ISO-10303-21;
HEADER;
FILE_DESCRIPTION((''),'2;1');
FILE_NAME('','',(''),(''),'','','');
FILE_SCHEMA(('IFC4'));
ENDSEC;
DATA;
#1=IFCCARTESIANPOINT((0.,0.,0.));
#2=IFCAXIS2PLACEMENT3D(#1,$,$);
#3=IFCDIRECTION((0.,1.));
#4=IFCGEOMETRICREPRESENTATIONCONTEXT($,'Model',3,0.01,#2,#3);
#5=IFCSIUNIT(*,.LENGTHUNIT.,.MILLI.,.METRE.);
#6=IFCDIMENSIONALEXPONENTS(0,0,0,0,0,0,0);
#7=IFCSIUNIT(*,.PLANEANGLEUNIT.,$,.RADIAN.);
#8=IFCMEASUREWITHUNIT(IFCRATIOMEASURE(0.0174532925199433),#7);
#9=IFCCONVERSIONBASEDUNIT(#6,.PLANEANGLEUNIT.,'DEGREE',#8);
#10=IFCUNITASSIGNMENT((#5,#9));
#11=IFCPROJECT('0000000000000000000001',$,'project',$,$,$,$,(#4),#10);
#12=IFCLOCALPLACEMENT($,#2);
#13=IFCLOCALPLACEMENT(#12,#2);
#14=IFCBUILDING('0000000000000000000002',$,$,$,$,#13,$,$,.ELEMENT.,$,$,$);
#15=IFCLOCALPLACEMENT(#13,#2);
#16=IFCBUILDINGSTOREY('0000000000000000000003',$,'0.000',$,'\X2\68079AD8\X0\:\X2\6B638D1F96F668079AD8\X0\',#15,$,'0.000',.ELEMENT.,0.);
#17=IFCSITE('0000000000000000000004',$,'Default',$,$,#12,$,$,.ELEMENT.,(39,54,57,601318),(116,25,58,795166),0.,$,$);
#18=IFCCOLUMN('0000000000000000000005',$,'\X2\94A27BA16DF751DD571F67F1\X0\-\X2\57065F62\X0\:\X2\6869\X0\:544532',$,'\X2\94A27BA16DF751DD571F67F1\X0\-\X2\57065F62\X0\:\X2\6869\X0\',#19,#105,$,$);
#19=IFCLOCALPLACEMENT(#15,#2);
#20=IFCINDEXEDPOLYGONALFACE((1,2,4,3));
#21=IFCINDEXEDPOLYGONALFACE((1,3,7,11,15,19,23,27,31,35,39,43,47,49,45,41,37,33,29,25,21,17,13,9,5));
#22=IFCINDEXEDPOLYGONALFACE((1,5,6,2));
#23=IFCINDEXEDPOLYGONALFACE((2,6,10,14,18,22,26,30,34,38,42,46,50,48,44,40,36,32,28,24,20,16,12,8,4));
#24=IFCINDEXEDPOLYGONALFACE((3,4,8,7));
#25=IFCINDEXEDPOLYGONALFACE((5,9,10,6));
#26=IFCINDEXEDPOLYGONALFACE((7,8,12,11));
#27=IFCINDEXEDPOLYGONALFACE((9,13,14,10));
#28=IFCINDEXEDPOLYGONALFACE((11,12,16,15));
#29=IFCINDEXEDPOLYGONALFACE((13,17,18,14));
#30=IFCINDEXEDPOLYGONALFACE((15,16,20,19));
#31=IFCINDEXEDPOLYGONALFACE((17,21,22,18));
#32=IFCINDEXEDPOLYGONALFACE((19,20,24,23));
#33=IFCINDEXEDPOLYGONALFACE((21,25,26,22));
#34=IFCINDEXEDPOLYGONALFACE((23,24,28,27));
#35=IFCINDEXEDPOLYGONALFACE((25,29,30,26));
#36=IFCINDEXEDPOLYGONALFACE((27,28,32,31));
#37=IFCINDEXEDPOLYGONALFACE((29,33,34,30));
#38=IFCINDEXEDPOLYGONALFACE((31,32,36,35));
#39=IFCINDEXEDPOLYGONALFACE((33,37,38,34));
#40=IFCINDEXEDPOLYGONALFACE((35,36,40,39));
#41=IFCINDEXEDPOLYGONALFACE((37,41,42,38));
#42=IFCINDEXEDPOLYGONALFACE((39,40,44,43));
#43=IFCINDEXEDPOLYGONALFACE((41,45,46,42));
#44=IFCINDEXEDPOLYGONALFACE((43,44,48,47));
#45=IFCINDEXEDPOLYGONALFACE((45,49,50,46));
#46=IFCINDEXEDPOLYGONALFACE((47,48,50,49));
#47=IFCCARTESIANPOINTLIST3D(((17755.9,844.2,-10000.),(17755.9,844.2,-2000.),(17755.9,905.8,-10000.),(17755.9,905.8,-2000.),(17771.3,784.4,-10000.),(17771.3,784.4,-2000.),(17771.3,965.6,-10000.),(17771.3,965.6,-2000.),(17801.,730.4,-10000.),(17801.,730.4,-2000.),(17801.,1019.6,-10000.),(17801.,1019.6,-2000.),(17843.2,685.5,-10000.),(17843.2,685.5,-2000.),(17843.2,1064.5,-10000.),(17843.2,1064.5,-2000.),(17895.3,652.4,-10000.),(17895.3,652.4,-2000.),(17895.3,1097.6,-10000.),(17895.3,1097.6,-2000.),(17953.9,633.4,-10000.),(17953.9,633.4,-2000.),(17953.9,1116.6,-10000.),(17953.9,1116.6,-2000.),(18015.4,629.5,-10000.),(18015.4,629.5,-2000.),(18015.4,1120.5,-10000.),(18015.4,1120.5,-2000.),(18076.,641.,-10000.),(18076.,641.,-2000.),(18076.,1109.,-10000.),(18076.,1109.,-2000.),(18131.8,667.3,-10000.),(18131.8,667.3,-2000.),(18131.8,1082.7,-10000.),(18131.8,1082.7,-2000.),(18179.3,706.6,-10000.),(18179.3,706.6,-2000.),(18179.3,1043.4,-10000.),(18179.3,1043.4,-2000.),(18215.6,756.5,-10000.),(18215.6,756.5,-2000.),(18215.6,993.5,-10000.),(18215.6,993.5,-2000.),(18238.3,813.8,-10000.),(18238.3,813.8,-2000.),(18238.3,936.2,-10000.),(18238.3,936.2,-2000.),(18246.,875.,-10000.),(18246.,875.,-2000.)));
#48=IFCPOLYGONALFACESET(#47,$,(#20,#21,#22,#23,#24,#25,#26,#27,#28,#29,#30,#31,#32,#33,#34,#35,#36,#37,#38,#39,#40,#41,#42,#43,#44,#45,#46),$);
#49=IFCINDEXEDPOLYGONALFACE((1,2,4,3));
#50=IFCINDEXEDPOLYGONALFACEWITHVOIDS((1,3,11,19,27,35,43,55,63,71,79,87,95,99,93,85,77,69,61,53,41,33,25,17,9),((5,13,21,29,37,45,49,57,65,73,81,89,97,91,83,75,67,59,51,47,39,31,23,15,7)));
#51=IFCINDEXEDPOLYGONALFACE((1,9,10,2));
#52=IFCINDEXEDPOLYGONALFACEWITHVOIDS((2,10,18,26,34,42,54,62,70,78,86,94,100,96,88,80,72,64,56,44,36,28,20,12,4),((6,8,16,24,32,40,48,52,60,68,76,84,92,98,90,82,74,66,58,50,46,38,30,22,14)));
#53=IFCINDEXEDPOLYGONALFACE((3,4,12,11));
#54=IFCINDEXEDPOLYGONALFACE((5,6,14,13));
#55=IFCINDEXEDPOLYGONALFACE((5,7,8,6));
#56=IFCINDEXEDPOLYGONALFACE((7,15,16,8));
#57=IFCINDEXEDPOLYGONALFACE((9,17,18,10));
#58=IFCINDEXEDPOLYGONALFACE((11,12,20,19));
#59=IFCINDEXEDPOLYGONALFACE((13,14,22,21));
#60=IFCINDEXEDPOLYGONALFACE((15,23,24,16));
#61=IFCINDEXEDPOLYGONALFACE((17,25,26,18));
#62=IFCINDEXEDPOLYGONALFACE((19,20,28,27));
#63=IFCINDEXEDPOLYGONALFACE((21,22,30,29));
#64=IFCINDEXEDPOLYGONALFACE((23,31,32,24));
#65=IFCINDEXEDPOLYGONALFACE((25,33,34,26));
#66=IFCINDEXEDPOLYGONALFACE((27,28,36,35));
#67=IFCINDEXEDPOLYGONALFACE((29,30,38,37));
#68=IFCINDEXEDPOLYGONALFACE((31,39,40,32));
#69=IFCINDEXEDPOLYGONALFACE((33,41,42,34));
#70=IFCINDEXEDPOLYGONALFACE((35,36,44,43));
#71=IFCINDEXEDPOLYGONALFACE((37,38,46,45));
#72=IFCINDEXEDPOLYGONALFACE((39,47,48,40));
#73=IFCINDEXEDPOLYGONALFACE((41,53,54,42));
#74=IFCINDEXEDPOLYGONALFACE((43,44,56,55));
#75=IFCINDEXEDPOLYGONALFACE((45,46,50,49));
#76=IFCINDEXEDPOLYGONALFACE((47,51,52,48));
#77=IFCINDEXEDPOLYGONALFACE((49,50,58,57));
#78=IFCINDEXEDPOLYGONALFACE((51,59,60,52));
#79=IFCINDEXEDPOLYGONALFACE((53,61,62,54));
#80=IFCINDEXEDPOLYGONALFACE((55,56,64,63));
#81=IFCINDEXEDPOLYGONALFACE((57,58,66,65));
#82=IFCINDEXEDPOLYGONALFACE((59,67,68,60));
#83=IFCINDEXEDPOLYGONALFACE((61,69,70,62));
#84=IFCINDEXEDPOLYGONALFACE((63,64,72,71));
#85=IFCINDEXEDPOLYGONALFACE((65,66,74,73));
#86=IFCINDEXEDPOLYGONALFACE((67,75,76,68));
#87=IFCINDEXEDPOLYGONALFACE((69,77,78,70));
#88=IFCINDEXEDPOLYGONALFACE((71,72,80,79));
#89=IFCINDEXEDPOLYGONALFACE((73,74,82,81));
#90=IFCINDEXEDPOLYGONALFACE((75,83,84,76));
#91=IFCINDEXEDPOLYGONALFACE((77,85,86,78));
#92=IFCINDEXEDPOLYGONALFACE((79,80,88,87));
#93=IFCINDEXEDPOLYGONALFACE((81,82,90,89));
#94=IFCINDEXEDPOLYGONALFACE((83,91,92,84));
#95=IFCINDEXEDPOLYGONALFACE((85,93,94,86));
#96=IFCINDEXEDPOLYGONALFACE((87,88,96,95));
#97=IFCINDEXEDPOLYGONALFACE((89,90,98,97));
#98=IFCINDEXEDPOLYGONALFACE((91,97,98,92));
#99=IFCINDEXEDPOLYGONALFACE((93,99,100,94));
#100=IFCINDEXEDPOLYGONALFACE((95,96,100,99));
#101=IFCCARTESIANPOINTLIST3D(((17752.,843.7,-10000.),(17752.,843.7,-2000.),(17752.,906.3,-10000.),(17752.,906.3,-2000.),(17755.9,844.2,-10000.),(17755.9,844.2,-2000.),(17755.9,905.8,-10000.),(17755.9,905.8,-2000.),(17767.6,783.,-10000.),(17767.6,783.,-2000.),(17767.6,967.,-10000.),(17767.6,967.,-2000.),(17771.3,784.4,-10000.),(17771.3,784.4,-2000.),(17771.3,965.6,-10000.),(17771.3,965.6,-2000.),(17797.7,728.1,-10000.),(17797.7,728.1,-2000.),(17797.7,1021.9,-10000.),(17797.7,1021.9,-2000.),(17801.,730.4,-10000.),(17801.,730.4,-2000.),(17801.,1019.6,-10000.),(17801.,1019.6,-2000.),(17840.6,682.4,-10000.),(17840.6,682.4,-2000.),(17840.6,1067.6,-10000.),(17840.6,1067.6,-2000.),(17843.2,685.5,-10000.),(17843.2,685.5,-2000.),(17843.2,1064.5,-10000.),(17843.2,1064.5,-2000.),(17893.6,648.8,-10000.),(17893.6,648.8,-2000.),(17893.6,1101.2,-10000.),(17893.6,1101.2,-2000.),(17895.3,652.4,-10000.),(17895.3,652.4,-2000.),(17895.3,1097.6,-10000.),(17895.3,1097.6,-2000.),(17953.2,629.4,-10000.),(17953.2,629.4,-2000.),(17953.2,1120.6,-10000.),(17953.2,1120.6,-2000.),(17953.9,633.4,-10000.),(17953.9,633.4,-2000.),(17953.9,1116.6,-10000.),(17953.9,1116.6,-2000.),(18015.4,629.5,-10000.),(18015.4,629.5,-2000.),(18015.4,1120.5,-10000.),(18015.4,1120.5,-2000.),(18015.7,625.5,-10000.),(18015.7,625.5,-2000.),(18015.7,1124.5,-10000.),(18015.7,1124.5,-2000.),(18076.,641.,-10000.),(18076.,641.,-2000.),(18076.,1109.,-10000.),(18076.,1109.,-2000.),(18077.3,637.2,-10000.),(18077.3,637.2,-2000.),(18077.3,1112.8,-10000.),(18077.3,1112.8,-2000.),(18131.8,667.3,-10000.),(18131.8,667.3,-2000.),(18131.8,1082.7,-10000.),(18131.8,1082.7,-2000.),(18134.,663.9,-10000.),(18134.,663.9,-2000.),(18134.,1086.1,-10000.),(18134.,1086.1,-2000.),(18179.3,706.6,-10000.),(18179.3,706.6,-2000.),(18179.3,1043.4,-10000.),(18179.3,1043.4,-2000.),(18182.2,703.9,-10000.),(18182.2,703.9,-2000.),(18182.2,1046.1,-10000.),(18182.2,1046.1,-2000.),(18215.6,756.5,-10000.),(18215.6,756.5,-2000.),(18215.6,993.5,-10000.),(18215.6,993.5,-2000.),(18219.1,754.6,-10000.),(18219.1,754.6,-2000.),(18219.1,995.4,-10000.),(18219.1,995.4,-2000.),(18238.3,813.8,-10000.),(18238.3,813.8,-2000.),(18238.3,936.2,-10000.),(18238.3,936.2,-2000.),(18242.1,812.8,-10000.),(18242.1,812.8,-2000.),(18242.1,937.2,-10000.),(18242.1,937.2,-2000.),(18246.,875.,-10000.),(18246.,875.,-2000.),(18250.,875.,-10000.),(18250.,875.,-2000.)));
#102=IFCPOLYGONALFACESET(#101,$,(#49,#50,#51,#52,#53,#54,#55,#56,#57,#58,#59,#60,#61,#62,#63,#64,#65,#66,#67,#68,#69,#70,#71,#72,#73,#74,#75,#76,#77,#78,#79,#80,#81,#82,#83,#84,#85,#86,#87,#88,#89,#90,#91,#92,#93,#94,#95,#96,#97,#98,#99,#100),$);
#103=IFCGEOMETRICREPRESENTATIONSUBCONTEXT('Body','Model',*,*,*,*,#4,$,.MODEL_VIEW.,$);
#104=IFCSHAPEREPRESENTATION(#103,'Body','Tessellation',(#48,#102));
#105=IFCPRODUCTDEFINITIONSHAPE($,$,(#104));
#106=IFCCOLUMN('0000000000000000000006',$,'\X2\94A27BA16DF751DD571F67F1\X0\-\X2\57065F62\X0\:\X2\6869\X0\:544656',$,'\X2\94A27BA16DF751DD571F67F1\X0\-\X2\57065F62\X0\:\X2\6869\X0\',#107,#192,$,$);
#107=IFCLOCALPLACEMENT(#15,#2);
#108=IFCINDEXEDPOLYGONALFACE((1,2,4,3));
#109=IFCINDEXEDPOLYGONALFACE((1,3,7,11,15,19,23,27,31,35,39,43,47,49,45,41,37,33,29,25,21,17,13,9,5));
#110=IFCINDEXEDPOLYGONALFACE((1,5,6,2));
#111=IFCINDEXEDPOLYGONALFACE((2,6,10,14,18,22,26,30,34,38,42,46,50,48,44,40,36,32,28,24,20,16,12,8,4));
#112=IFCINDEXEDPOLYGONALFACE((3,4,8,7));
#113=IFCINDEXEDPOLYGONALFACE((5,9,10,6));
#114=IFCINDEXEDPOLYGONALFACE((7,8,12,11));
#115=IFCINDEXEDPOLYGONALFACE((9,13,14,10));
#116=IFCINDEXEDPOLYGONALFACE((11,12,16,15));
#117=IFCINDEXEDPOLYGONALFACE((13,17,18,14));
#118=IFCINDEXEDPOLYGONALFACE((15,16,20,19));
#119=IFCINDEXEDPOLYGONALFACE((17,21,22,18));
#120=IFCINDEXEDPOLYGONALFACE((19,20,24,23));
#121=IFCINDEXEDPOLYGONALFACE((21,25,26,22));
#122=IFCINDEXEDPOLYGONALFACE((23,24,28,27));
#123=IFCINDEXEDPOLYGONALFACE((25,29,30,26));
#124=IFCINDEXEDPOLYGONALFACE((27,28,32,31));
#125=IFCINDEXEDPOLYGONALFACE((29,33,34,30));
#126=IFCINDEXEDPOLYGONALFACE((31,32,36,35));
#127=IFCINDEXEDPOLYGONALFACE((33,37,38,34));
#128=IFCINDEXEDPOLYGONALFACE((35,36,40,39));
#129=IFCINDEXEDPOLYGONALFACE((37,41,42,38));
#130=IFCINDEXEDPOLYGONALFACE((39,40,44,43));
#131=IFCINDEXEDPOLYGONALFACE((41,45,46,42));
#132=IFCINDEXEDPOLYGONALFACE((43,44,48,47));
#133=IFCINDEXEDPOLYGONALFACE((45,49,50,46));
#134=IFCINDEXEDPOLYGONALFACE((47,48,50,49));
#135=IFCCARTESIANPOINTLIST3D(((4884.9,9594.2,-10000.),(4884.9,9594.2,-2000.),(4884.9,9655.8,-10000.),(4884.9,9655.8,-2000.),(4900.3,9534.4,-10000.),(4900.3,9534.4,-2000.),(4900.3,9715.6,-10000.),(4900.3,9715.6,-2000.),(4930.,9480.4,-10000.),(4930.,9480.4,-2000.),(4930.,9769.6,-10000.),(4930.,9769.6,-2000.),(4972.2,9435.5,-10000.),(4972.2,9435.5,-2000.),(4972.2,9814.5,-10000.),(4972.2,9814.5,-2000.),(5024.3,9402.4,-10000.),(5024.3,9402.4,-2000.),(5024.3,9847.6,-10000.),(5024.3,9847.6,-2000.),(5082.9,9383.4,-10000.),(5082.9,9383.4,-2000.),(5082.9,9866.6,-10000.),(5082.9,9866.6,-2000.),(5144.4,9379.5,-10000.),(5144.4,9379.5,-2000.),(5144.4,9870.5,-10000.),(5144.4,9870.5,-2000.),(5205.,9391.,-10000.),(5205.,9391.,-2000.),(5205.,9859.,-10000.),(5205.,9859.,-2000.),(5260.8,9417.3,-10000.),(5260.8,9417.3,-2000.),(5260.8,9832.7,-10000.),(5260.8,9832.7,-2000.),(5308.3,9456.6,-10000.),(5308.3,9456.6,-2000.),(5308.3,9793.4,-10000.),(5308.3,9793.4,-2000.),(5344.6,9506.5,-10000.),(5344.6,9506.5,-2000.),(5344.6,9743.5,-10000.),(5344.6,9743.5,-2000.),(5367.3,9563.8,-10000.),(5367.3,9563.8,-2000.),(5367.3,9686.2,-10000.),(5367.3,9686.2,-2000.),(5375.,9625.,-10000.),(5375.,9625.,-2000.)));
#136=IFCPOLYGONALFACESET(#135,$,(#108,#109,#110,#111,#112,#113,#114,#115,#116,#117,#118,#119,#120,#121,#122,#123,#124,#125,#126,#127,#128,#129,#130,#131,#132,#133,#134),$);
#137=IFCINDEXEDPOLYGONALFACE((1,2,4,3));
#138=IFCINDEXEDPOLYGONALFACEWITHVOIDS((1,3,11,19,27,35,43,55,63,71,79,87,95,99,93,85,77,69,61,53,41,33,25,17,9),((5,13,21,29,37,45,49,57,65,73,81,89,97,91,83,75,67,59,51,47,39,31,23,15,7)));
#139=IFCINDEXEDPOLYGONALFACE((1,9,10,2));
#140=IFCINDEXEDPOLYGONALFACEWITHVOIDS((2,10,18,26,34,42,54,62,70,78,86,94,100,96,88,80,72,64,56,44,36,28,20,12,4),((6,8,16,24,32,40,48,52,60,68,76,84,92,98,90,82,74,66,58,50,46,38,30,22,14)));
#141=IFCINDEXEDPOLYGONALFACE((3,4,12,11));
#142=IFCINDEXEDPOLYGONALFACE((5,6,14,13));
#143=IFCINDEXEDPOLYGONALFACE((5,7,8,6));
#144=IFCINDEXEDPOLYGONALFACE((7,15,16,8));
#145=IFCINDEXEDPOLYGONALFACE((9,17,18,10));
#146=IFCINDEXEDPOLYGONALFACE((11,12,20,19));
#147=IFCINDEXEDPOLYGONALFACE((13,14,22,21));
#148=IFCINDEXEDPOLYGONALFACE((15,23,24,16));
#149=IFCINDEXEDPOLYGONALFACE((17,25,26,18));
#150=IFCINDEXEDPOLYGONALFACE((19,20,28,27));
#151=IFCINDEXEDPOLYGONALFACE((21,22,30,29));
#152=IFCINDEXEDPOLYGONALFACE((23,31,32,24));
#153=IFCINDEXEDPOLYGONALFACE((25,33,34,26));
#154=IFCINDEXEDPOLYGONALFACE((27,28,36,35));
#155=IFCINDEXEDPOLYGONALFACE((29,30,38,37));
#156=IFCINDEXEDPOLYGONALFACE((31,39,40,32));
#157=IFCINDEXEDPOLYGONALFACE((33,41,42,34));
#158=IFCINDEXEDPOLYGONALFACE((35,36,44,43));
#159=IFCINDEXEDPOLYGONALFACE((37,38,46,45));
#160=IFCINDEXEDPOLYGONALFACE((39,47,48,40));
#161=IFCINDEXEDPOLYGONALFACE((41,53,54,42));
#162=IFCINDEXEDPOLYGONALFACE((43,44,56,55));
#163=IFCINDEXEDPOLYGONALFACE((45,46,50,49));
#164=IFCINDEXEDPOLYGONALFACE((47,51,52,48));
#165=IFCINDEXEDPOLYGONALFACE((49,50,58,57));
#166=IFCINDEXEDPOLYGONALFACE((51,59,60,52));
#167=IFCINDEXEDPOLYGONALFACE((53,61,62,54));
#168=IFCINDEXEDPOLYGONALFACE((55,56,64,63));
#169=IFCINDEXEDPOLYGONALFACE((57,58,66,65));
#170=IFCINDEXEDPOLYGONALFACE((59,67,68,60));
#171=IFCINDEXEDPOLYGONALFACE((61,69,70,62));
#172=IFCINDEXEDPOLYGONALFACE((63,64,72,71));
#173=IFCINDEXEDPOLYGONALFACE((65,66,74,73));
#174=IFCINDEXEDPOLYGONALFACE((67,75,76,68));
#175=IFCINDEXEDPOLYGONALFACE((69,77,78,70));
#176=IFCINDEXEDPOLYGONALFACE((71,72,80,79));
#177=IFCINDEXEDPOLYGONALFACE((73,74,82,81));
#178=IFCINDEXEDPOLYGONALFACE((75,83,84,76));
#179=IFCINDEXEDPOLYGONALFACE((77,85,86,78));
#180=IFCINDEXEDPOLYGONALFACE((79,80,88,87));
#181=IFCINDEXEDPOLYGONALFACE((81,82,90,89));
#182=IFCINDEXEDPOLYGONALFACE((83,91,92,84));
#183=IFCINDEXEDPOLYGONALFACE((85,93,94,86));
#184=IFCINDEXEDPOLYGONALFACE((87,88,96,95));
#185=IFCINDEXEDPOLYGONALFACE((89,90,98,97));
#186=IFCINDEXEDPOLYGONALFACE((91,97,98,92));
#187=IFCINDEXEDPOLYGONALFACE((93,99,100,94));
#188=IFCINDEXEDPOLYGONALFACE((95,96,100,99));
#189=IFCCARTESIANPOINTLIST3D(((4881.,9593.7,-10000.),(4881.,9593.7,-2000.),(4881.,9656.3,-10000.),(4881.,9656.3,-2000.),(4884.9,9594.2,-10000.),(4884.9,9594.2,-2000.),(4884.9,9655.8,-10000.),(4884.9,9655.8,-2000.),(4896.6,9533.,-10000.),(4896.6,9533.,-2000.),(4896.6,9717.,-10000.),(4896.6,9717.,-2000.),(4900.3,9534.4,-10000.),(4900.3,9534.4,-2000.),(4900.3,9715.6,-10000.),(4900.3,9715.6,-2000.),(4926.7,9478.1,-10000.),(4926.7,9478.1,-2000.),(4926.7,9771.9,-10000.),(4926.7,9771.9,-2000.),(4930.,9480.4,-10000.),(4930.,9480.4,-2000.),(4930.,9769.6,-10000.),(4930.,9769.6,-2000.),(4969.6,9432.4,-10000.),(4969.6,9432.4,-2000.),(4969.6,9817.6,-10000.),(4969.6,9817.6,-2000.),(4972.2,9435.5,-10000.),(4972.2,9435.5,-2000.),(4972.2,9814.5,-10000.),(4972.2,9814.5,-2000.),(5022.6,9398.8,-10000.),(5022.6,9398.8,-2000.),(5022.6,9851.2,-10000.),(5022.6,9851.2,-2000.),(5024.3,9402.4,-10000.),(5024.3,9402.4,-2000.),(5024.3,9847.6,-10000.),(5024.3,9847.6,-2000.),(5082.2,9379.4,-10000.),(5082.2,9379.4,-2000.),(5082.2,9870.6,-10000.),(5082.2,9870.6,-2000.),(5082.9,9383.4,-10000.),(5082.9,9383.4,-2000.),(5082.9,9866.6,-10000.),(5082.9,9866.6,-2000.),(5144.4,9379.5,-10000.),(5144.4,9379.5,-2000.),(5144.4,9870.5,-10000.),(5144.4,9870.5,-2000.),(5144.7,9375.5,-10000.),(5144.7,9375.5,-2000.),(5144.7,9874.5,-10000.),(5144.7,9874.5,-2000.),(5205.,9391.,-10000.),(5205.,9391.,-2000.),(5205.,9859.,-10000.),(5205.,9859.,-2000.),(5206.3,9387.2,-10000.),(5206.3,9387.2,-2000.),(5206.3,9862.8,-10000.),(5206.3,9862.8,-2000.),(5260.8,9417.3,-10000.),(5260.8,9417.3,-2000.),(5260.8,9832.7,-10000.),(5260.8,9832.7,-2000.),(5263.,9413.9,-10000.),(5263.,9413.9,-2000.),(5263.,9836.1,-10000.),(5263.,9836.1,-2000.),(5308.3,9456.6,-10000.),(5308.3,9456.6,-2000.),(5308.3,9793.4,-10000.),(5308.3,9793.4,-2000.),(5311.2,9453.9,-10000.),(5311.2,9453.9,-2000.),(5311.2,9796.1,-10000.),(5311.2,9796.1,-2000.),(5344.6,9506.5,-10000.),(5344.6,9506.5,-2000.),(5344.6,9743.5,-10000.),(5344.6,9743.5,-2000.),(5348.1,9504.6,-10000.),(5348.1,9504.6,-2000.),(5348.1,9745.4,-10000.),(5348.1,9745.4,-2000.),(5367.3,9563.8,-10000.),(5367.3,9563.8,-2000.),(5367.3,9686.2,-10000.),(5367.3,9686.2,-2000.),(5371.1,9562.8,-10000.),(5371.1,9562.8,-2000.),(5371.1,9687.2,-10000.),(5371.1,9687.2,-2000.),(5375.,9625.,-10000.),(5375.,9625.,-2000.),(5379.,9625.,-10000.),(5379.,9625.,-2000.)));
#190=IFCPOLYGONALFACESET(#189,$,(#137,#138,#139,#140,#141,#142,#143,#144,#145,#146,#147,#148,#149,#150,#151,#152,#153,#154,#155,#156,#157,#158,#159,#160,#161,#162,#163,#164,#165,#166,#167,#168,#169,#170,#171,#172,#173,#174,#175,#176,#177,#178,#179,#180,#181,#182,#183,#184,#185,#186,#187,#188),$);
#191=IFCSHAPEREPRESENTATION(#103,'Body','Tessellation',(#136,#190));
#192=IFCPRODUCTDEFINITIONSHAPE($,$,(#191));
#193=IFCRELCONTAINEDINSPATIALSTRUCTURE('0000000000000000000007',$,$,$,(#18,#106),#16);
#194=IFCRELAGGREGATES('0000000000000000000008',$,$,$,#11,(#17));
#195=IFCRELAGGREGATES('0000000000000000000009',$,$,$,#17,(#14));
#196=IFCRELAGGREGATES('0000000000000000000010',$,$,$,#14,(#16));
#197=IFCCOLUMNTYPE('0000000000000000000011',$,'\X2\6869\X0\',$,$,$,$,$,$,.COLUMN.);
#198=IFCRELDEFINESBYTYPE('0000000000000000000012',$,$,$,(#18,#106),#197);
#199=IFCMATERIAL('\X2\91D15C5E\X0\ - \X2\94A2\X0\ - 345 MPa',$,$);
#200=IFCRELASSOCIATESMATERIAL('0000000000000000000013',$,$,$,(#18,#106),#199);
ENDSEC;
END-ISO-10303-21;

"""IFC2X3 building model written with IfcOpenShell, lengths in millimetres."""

from ifc_helpers import new_model, entity, si_unit, converted_unit, direction, frame, frame_2d, origin, place, context, subcontext, project, spatial, circle, hollow_circle, extrude, source, transform, mapped, material, type_object, type_shapes, element, save


model = new_model("IFC2X3")

# Units and contexts
model_context = context("Model", 3, precision=0.01, world=origin(), true_north=direction((0.0, 1.0)))
body_context = subcontext(model_context, "Body", "Model", "MODEL_VIEW")
ifc_project = project(units=[si_unit("LENGTHUNIT", "METRE", prefix="MILLI"), converted_unit("PLANEANGLEUNIT", "DEGREE", entity("IfcRatioMeasure", 0.0174532925199433), si_unit("PLANEANGLEUNIT", "RADIAN"), dimensions=[0, 0, 0, 0, 0, 0, 0])], contexts=[model_context])

# Site, building, storey
site_placement = place(None, origin())
site = spatial("IfcSite", under=ifc_project, at=site_placement, Name="Default", CompositionType="ELEMENT", RefLatitude=(39, 54, 57, 601318), RefLongitude=(116, 25, 58, 795166), RefElevation=0.0)
building_placement = place(site_placement, origin())
building = spatial("IfcBuilding", under=site, at=building_placement, CompositionType="ELEMENT")
storey_placement = place(building_placement, origin())
storey = spatial("IfcBuildingStorey", under=building, at=storey_placement, Name="0.000", ObjectType="标高:正负零标高", LongName="0.000", CompositionType="ELEMENT", Elevation=0.0)

# Columns
ifc_material_1 = material(Name="金属 - 钢 - 345 MPa")
column_type = type_object("IfcColumnType", Name="桩", PredefinedType="COLUMN")
shared_shape = source(origin(), body_context, "Body", "SweptSolid", [
    extrude(circle(Radius=246.0, at=frame_2d((0.0, 0.0), x_axis=(1.0, 0.0))), frame((0.0, 0.0, -10000.0)), (0.0, 0.0, 1.0), 8000.0),
    extrude(hollow_circle(Radius=250.0, WallThickness=4.0, at=frame_2d((0.0, 0.0), x_axis=(1.0, 0.0))), frame((0.0, 0.0, -10000.0)), (0.0, 0.0, 1.0), 8000.0),
])
type_shapes(column_type, [shared_shape])
for number, where, name in (
    (1, (18000.0, 875.0, 0.0), "钢管混凝土柱-圆形:桩:544532"),
    (2, (5129.0, 9625.0, 0.0), "钢管混凝土柱-圆形:桩:544656"),
):
    element("IfcColumn", number, at=place(storey_placement, frame(where)), inside=storey, type_object=column_type, material=ifc_material_1, Name=name, ObjectType="钢管混凝土柱-圆形:桩", context=body_context, shape_type="MappedRepresentation", body=[
        mapped(shared_shape, transform((0.0, 0.0, 0.0), scale=1.0)),
    ])

save(model, "model.ifc")
